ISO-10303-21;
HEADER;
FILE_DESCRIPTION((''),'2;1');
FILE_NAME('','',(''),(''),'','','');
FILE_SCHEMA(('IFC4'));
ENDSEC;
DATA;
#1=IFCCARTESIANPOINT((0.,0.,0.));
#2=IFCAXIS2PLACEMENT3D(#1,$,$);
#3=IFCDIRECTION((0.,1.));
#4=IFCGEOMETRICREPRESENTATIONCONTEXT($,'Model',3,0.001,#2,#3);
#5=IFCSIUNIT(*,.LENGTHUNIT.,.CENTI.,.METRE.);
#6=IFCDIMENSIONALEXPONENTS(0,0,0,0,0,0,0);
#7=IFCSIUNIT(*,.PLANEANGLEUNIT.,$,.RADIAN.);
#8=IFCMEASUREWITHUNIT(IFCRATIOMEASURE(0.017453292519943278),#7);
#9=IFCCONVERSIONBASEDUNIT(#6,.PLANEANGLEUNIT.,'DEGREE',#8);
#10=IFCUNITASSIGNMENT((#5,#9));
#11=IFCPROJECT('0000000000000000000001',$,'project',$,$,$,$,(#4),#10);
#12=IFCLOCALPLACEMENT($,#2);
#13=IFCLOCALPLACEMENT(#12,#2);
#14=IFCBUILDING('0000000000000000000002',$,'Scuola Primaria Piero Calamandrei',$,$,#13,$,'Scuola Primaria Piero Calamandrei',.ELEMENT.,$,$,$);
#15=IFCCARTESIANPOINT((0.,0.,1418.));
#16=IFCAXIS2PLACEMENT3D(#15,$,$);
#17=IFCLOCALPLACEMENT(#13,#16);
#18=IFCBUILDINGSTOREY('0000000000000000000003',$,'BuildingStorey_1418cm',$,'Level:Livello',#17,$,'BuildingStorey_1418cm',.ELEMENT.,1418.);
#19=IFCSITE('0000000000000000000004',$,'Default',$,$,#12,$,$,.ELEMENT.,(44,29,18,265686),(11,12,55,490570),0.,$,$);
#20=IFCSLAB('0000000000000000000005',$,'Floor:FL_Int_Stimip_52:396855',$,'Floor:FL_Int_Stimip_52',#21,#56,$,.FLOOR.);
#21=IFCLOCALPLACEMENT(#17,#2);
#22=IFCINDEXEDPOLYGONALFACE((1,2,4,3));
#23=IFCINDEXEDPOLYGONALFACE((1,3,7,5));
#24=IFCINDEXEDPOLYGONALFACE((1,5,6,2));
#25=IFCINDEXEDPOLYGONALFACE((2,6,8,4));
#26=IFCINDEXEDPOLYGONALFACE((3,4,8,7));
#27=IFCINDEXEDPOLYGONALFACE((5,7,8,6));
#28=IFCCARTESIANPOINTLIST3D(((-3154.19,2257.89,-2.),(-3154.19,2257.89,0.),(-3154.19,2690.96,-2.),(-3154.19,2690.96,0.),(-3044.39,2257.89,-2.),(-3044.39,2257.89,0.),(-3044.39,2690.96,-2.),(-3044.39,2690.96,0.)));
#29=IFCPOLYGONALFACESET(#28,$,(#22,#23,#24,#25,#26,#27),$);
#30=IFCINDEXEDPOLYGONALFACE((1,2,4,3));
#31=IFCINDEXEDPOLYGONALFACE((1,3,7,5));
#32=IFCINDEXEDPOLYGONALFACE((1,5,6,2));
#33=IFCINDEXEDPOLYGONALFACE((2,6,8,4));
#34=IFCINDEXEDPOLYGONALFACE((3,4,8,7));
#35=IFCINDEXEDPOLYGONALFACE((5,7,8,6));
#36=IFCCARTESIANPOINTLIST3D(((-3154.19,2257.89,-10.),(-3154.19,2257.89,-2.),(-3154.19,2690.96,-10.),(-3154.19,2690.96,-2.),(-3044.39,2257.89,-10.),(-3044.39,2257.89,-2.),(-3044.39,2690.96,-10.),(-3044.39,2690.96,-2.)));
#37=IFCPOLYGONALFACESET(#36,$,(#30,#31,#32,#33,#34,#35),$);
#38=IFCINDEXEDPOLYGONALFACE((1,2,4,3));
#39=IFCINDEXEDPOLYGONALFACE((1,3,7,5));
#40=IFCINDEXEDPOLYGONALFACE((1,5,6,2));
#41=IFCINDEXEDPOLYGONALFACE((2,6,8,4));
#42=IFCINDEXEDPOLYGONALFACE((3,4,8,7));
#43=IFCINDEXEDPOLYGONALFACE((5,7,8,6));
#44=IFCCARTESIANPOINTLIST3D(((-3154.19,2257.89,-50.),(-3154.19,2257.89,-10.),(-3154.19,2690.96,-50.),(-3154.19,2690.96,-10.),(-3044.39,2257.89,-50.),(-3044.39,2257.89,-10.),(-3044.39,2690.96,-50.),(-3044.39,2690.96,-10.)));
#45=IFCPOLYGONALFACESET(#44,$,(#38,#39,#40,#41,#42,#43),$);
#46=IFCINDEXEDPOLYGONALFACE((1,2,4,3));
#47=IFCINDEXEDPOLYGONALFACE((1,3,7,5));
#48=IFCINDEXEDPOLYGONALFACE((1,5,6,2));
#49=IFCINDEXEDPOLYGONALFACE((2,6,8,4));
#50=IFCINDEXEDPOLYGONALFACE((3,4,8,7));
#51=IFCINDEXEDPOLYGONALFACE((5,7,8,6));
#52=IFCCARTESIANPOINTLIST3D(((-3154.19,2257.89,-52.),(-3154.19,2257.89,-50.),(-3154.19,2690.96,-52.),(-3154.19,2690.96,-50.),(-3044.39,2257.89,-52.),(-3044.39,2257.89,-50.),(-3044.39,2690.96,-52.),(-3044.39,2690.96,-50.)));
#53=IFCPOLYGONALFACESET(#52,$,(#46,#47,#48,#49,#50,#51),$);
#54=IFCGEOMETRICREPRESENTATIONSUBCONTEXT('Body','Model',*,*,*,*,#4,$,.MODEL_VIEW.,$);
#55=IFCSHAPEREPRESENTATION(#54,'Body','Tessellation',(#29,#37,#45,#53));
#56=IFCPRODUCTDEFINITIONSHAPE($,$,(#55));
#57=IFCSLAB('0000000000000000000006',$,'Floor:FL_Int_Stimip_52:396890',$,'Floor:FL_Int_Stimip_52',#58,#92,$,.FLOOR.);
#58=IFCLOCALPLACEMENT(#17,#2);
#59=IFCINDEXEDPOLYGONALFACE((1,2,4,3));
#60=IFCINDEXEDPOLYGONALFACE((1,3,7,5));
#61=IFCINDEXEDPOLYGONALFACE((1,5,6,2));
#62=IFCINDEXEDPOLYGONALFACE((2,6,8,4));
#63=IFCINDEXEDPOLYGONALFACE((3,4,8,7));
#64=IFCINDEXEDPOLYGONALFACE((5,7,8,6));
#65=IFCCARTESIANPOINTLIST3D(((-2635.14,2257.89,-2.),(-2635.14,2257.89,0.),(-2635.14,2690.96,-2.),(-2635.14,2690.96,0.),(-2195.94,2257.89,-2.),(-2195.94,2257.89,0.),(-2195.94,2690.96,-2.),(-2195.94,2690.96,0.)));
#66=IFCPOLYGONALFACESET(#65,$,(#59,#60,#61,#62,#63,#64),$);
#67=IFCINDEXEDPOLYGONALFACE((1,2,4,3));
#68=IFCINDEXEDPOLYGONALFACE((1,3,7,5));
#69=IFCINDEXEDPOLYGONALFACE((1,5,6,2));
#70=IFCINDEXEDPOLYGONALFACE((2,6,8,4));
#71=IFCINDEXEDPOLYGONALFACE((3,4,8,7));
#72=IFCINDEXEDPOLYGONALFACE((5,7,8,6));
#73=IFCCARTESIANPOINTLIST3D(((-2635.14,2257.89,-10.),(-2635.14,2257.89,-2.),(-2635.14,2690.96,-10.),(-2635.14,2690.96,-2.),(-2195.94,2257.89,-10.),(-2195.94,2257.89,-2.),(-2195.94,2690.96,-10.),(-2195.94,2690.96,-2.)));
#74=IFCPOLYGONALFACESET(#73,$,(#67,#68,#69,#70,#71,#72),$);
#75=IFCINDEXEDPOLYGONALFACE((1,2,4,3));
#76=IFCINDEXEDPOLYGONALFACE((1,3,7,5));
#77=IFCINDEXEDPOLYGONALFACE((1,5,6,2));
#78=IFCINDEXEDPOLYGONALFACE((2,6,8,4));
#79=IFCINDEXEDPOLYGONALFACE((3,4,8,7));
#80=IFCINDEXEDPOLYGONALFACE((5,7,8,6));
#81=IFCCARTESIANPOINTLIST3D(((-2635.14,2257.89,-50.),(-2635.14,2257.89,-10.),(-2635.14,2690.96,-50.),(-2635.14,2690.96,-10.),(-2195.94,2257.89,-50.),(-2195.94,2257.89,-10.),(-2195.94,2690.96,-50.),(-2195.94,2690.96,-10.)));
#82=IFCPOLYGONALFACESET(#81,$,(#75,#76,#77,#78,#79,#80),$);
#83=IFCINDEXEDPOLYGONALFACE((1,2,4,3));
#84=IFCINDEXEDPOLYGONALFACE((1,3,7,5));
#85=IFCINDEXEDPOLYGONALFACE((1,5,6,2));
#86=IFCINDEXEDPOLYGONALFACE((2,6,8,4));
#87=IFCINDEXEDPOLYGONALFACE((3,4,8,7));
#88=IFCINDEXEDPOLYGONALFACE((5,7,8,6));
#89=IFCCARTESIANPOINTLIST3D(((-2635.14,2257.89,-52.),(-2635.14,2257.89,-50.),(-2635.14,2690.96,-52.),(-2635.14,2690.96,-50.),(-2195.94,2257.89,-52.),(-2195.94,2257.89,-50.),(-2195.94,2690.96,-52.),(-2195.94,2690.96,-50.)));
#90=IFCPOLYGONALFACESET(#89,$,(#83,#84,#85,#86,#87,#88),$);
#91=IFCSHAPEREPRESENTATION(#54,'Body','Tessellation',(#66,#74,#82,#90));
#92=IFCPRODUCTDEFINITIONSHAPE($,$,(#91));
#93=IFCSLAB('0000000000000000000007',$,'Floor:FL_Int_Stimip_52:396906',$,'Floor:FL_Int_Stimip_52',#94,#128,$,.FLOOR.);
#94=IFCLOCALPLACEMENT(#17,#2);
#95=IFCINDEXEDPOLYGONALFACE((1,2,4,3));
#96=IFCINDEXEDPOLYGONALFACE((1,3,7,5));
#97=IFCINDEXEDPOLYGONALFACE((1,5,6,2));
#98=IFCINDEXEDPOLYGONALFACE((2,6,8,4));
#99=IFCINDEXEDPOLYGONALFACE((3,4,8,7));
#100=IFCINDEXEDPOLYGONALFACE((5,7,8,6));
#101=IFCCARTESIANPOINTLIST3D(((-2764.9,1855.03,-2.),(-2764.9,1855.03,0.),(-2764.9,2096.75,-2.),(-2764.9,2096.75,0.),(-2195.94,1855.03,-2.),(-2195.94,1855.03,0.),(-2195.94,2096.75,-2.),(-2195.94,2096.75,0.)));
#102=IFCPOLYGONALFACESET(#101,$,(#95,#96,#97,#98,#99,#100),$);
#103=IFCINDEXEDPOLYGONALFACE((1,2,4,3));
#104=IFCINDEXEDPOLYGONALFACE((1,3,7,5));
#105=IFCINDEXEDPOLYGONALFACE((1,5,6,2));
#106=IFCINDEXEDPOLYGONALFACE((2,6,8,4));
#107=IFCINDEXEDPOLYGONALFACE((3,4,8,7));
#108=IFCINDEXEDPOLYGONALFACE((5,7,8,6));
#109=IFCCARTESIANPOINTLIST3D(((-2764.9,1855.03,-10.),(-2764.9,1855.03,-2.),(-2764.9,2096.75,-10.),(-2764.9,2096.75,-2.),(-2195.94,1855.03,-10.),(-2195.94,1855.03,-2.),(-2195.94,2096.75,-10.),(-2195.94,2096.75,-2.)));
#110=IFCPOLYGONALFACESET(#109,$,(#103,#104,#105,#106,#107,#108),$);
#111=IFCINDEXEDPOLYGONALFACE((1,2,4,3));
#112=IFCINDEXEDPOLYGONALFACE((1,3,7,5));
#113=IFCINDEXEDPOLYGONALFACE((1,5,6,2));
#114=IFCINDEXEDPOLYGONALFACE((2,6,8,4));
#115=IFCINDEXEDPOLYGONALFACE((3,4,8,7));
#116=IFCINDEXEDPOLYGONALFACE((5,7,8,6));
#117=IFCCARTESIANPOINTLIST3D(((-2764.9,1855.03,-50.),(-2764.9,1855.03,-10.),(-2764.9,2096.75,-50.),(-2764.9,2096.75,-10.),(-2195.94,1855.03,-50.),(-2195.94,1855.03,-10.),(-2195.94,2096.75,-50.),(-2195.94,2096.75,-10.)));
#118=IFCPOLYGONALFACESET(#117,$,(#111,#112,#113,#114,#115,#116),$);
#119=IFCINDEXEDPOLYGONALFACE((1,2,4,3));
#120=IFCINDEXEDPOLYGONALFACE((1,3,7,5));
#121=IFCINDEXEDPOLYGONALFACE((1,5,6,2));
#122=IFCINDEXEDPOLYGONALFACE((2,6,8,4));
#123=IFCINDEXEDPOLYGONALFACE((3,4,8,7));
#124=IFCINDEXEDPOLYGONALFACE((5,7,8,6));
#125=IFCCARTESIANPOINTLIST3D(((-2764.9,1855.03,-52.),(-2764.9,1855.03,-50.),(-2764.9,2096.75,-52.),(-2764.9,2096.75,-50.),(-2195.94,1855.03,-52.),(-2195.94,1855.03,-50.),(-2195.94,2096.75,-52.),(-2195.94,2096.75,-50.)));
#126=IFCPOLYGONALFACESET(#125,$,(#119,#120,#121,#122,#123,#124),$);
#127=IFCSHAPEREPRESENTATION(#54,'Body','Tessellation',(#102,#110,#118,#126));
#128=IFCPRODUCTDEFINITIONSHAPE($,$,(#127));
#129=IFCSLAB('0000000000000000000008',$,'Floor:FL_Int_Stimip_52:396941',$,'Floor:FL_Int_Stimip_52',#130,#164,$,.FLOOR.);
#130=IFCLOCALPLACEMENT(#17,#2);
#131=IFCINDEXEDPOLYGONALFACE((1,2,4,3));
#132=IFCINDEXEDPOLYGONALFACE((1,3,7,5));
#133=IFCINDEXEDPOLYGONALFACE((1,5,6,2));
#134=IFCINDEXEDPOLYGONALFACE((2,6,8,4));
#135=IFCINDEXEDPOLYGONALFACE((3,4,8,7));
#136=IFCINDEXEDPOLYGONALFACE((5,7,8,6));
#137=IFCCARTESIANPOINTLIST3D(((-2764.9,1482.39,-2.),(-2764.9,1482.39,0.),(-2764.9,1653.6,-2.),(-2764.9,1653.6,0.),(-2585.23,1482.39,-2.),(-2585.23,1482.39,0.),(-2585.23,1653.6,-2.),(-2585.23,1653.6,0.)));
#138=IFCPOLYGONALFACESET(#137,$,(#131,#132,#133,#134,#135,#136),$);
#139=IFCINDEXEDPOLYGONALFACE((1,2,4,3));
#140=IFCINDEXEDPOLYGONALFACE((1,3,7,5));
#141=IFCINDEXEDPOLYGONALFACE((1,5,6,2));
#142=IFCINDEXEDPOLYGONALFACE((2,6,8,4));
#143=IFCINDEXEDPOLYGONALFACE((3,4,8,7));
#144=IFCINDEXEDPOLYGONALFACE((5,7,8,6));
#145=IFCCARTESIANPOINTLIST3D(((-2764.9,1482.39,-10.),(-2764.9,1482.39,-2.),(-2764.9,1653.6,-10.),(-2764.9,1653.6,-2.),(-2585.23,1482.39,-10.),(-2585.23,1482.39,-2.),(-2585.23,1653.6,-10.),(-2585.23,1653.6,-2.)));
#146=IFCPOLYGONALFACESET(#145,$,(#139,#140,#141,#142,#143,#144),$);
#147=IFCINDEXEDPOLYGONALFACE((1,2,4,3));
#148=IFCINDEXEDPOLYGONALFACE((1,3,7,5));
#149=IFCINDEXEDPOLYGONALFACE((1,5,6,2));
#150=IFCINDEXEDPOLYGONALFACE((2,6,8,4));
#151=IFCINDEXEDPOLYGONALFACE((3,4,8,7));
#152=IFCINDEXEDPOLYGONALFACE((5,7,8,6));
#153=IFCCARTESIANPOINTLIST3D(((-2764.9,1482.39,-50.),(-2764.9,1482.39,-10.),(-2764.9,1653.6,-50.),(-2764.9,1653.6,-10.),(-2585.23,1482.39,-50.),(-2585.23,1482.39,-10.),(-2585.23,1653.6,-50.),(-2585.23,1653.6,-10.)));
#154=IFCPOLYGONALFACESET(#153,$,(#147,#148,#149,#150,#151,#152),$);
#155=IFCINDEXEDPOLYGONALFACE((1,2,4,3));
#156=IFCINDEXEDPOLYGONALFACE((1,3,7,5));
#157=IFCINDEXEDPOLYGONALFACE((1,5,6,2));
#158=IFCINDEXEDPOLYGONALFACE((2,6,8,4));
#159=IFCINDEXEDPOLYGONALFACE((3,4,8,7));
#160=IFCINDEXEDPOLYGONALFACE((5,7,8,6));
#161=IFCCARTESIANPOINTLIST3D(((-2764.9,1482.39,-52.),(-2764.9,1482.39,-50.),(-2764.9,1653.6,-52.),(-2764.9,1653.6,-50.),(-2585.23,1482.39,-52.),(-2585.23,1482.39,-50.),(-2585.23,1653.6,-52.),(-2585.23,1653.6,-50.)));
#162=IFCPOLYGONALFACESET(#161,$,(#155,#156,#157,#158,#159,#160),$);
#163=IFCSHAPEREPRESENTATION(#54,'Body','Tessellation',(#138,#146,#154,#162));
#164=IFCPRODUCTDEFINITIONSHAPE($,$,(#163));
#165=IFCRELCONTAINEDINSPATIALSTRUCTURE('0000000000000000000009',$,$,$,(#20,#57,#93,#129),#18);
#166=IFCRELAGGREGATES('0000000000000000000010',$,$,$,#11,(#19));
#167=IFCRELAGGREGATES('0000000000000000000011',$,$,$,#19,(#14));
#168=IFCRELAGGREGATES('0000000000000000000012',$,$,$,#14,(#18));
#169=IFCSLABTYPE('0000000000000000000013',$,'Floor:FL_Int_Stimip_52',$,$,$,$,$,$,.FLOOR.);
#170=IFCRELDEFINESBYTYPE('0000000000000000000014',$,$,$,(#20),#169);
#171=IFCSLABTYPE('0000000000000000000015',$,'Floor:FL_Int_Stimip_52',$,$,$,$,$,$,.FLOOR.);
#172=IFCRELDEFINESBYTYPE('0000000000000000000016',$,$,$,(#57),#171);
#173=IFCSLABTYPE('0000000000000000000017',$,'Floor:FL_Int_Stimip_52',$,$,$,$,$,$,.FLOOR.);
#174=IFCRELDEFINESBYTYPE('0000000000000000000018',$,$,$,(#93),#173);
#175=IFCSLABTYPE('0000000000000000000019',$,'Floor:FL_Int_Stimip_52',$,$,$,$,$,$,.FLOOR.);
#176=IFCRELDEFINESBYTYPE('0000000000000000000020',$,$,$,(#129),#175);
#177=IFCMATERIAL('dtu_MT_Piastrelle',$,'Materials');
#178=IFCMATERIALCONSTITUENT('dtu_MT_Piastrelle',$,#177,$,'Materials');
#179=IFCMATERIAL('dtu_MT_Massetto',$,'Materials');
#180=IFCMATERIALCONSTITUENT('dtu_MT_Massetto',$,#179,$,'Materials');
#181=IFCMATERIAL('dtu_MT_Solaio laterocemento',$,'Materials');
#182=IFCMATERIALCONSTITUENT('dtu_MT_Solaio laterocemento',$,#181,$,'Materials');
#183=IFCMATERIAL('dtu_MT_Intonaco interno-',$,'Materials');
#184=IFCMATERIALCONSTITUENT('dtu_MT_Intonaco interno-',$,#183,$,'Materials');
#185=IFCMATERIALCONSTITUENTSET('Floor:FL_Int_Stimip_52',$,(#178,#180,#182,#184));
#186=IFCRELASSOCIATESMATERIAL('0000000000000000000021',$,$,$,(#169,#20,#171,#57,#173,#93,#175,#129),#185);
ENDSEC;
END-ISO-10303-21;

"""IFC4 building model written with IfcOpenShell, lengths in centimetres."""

from ifc_helpers import new_model, entity, si_unit, converted_unit, direction, frame, origin, place, context, subcontext, project, spatial, indexed_curve, outline, extrude, material, constituent, constituent_set, type_object, element, save


model = new_model("IFC4")

# Units and contexts
model_context = context("Model", 3, precision=0.001, world=origin(), true_north=direction((0.0, 1.0)))
body_context = subcontext(model_context, "Body", "Model", "MODEL_VIEW")
ifc_project = project(units=[si_unit("LENGTHUNIT", "METRE", prefix="CENTI"), converted_unit("PLANEANGLEUNIT", "DEGREE", entity("IfcRatioMeasure", 0.017453292519943278), si_unit("PLANEANGLEUNIT", "RADIAN"), dimensions=[0, 0, 0, 0, 0, 0, 0])], contexts=[model_context])

# Site, building, storey
site_placement = place(None, origin())
site = spatial("IfcSite", under=ifc_project, at=site_placement, Name="Default", CompositionType="ELEMENT", RefLatitude=(44, 29, 18, 265686), RefLongitude=(11, 12, 55, 490570), RefElevation=0.0)
building_placement = place(site_placement, origin())
building = spatial("IfcBuilding", under=site, at=building_placement, Name="Scuola Primaria Piero Calamandrei", LongName="Scuola Primaria Piero Calamandrei", CompositionType="ELEMENT")
storey_placement = place(building_placement, frame((0.0, 0.0, 1418.0)))
storey = spatial("IfcBuildingStorey", under=building, at=storey_placement, Name="BuildingStorey_1418cm", ObjectType="Level:Livello", LongName="BuildingStorey_1418cm", CompositionType="ELEMENT", Elevation=1418.0)

# Slabs
ifc_material_1 = material(Name="dtu_MT_Piastrelle", Category="Materials")
ifc_constituent_1 = constituent(ifc_material_1, Name="dtu_MT_Piastrelle", Category="Materials")
ifc_material_2 = material(Name="dtu_MT_Massetto", Category="Materials")
ifc_constituent_2 = constituent(ifc_material_2, Name="dtu_MT_Massetto", Category="Materials")
ifc_material_3 = material(Name="dtu_MT_Solaio laterocemento", Category="Materials")
ifc_constituent_3 = constituent(ifc_material_3, Name="dtu_MT_Solaio laterocemento", Category="Materials")
ifc_material_4 = material(Name="dtu_MT_Intonaco interno-", Category="Materials")
ifc_constituent_4 = constituent(ifc_material_4, Name="dtu_MT_Intonaco interno-", Category="Materials")
ifc_constituent_set = constituent_set(constituents=[ifc_constituent_1, ifc_constituent_2, ifc_constituent_3, ifc_constituent_4], Name="Floor:FL_Int_Stimip_52")
slab_type_1 = type_object("IfcSlabType", Name="Floor:FL_Int_Stimip_52", PredefinedType="FLOOR", material=ifc_constituent_set)
slab_1_placement = place(storey_placement, origin())
element("IfcSlab", 1, at=slab_1_placement, inside=storey, type_object=slab_type_1, material=ifc_constituent_set, Name="Floor:FL_Int_Stimip_52:396855", ObjectType="Floor:FL_Int_Stimip_52", PredefinedType="FLOOR", context=body_context, shape_type="SweptSolid", body=[
    extrude(outline(indexed_curve([(-216.54, -54.9), (216.54, -54.9), (216.54, 54.9), (-216.54, 54.9), (-216.54, -54.9)], self_intersect=False)), frame((-3099.29, 2474.42, -2.0), z_axis=(0.0, 0.0, 1.0), x_axis=(0.0, -1.0, 0.0)), (0.0, 0.0, 1.0), 2.0),
    extrude(outline(indexed_curve([(-216.54, -54.9), (216.54, -54.9), (216.54, 54.9), (-216.54, 54.9), (-216.54, -54.9)], self_intersect=False)), frame((-3099.29, 2474.42, -10.0), z_axis=(0.0, 0.0, 1.0), x_axis=(0.0, -1.0, 0.0)), (0.0, 0.0, 1.0), 8.0),
    extrude(outline(indexed_curve([(-216.54, -54.9), (216.54, -54.9), (216.54, 54.9), (-216.54, 54.9), (-216.54, -54.9)], self_intersect=False)), frame((-3099.29, 2474.42, -50.0), z_axis=(0.0, 0.0, 1.0), x_axis=(0.0, -1.0, 0.0)), (0.0, 0.0, 1.0), 40.0),
    extrude(outline(indexed_curve([(-216.54, -54.9), (216.54, -54.9), (216.54, 54.9), (-216.54, 54.9), (-216.54, -54.9)], self_intersect=False)), frame((-3099.29, 2474.42, -52.0), z_axis=(0.0, 0.0, 1.0), x_axis=(0.0, -1.0, 0.0)), (0.0, 0.0, 1.0), 2.0),
])
slab_type_2 = type_object("IfcSlabType", Name="Floor:FL_Int_Stimip_52", PredefinedType="FLOOR", material=ifc_constituent_set)
slab_2_placement = place(storey_placement, origin())
element("IfcSlab", 2, at=slab_2_placement, inside=storey, type_object=slab_type_2, material=ifc_constituent_set, Name="Floor:FL_Int_Stimip_52:396890", ObjectType="Floor:FL_Int_Stimip_52", PredefinedType="FLOOR", context=body_context, shape_type="SweptSolid", body=[
    extrude(outline(indexed_curve([(-219.6, -216.54), (219.6, -216.54), (219.6, 216.54), (-219.6, 216.54), (-219.6, -216.54)], self_intersect=False)), frame((-2415.54, 2474.42, -2.0), z_axis=(0.0, 0.0, 1.0), x_axis=(-1.0, 0.0, 0.0)), (0.0, 0.0, 1.0), 2.0),
    extrude(outline(indexed_curve([(-219.6, -216.54), (219.6, -216.54), (219.6, 216.54), (-219.6, 216.54), (-219.6, -216.54)], self_intersect=False)), frame((-2415.54, 2474.42, -10.0), z_axis=(0.0, 0.0, 1.0), x_axis=(-1.0, 0.0, 0.0)), (0.0, 0.0, 1.0), 8.0),
    extrude(outline(indexed_curve([(-219.6, -216.54), (219.6, -216.54), (219.6, 216.54), (-219.6, 216.54), (-219.6, -216.54)], self_intersect=False)), frame((-2415.54, 2474.42, -50.0), z_axis=(0.0, 0.0, 1.0), x_axis=(-1.0, 0.0, 0.0)), (0.0, 0.0, 1.0), 40.0),
    extrude(outline(indexed_curve([(-219.6, -216.54), (219.6, -216.54), (219.6, 216.54), (-219.6, 216.54), (-219.6, -216.54)], self_intersect=False)), frame((-2415.54, 2474.42, -52.0), z_axis=(0.0, 0.0, 1.0), x_axis=(-1.0, 0.0, 0.0)), (0.0, 0.0, 1.0), 2.0),
])
slab_type_3 = type_object("IfcSlabType", Name="Floor:FL_Int_Stimip_52", PredefinedType="FLOOR", material=ifc_constituent_set)
slab_3_placement = place(storey_placement, origin())
element("IfcSlab", 3, at=slab_3_placement, inside=storey, type_object=slab_type_3, material=ifc_constituent_set, Name="Floor:FL_Int_Stimip_52:396906", ObjectType="Floor:FL_Int_Stimip_52", PredefinedType="FLOOR", context=body_context, shape_type="SweptSolid", body=[
    extrude(outline(indexed_curve([(-284.48, -120.86), (284.48, -120.86), (284.48, 120.86), (-284.48, 120.86), (-284.48, -120.86)], self_intersect=False)), frame((-2480.42, 1975.89, -2.0), z_axis=(0.0, 0.0, 1.0), x_axis=(-1.0, 0.0, 0.0)), (0.0, 0.0, 1.0), 2.0),
    extrude(outline(indexed_curve([(-284.48, -120.86), (284.48, -120.86), (284.48, 120.86), (-284.48, 120.86), (-284.48, -120.86)], self_intersect=False)), frame((-2480.42, 1975.89, -10.0), z_axis=(0.0, 0.0, 1.0), x_axis=(-1.0, 0.0, 0.0)), (0.0, 0.0, 1.0), 8.0),
    extrude(outline(indexed_curve([(-284.48, -120.86), (284.48, -120.86), (284.48, 120.86), (-284.48, 120.86), (-284.48, -120.86)], self_intersect=False)), frame((-2480.42, 1975.89, -50.0), z_axis=(0.0, 0.0, 1.0), x_axis=(-1.0, 0.0, 0.0)), (0.0, 0.0, 1.0), 40.0),
    extrude(outline(indexed_curve([(-284.48, -120.86), (284.48, -120.86), (284.48, 120.86), (-284.48, 120.86), (-284.48, -120.86)], self_intersect=False)), frame((-2480.42, 1975.89, -52.0), z_axis=(0.0, 0.0, 1.0), x_axis=(-1.0, 0.0, 0.0)), (0.0, 0.0, 1.0), 2.0),
])
slab_type_4 = type_object("IfcSlabType", Name="Floor:FL_Int_Stimip_52", PredefinedType="FLOOR", material=ifc_constituent_set)
slab_4_placement = place(storey_placement, origin())
element("IfcSlab", 4, at=slab_4_placement, inside=storey, type_object=slab_type_4, material=ifc_constituent_set, Name="Floor:FL_Int_Stimip_52:396941", ObjectType="Floor:FL_Int_Stimip_52", PredefinedType="FLOOR", context=body_context, shape_type="SweptSolid", body=[
    extrude(outline(indexed_curve([(-89.84, -85.61), (89.84, -85.61), (89.84, 85.61), (-89.84, 85.61), (-89.84, -85.61)], self_intersect=False)), frame((-2675.07, 1568.0, -2.0), z_axis=(0.0, 0.0, 1.0), x_axis=(-1.0, 0.0, 0.0)), (0.0, 0.0, 1.0), 2.0),
    extrude(outline(indexed_curve([(-89.84, -85.61), (89.84, -85.61), (89.84, 85.61), (-89.84, 85.61), (-89.84, -85.61)], self_intersect=False)), frame((-2675.07, 1568.0, -10.0), z_axis=(0.0, 0.0, 1.0), x_axis=(-1.0, 0.0, 0.0)), (0.0, 0.0, 1.0), 8.0),
    extrude(outline(indexed_curve([(-89.84, -85.61), (89.84, -85.61), (89.84, 85.61), (-89.84, 85.61), (-89.84, -85.61)], self_intersect=False)), frame((-2675.07, 1568.0, -50.0), z_axis=(0.0, 0.0, 1.0), x_axis=(-1.0, 0.0, 0.0)), (0.0, 0.0, 1.0), 40.0),
    extrude(outline(indexed_curve([(-89.84, -85.61), (89.84, -85.61), (89.84, 85.61), (-89.84, 85.61), (-89.84, -85.61)], self_intersect=False)), frame((-2675.07, 1568.0, -52.0), z_axis=(0.0, 0.0, 1.0), x_axis=(-1.0, 0.0, 0.0)), (0.0, 0.0, 1.0), 2.0),
])

save(model, "model.ifc")
